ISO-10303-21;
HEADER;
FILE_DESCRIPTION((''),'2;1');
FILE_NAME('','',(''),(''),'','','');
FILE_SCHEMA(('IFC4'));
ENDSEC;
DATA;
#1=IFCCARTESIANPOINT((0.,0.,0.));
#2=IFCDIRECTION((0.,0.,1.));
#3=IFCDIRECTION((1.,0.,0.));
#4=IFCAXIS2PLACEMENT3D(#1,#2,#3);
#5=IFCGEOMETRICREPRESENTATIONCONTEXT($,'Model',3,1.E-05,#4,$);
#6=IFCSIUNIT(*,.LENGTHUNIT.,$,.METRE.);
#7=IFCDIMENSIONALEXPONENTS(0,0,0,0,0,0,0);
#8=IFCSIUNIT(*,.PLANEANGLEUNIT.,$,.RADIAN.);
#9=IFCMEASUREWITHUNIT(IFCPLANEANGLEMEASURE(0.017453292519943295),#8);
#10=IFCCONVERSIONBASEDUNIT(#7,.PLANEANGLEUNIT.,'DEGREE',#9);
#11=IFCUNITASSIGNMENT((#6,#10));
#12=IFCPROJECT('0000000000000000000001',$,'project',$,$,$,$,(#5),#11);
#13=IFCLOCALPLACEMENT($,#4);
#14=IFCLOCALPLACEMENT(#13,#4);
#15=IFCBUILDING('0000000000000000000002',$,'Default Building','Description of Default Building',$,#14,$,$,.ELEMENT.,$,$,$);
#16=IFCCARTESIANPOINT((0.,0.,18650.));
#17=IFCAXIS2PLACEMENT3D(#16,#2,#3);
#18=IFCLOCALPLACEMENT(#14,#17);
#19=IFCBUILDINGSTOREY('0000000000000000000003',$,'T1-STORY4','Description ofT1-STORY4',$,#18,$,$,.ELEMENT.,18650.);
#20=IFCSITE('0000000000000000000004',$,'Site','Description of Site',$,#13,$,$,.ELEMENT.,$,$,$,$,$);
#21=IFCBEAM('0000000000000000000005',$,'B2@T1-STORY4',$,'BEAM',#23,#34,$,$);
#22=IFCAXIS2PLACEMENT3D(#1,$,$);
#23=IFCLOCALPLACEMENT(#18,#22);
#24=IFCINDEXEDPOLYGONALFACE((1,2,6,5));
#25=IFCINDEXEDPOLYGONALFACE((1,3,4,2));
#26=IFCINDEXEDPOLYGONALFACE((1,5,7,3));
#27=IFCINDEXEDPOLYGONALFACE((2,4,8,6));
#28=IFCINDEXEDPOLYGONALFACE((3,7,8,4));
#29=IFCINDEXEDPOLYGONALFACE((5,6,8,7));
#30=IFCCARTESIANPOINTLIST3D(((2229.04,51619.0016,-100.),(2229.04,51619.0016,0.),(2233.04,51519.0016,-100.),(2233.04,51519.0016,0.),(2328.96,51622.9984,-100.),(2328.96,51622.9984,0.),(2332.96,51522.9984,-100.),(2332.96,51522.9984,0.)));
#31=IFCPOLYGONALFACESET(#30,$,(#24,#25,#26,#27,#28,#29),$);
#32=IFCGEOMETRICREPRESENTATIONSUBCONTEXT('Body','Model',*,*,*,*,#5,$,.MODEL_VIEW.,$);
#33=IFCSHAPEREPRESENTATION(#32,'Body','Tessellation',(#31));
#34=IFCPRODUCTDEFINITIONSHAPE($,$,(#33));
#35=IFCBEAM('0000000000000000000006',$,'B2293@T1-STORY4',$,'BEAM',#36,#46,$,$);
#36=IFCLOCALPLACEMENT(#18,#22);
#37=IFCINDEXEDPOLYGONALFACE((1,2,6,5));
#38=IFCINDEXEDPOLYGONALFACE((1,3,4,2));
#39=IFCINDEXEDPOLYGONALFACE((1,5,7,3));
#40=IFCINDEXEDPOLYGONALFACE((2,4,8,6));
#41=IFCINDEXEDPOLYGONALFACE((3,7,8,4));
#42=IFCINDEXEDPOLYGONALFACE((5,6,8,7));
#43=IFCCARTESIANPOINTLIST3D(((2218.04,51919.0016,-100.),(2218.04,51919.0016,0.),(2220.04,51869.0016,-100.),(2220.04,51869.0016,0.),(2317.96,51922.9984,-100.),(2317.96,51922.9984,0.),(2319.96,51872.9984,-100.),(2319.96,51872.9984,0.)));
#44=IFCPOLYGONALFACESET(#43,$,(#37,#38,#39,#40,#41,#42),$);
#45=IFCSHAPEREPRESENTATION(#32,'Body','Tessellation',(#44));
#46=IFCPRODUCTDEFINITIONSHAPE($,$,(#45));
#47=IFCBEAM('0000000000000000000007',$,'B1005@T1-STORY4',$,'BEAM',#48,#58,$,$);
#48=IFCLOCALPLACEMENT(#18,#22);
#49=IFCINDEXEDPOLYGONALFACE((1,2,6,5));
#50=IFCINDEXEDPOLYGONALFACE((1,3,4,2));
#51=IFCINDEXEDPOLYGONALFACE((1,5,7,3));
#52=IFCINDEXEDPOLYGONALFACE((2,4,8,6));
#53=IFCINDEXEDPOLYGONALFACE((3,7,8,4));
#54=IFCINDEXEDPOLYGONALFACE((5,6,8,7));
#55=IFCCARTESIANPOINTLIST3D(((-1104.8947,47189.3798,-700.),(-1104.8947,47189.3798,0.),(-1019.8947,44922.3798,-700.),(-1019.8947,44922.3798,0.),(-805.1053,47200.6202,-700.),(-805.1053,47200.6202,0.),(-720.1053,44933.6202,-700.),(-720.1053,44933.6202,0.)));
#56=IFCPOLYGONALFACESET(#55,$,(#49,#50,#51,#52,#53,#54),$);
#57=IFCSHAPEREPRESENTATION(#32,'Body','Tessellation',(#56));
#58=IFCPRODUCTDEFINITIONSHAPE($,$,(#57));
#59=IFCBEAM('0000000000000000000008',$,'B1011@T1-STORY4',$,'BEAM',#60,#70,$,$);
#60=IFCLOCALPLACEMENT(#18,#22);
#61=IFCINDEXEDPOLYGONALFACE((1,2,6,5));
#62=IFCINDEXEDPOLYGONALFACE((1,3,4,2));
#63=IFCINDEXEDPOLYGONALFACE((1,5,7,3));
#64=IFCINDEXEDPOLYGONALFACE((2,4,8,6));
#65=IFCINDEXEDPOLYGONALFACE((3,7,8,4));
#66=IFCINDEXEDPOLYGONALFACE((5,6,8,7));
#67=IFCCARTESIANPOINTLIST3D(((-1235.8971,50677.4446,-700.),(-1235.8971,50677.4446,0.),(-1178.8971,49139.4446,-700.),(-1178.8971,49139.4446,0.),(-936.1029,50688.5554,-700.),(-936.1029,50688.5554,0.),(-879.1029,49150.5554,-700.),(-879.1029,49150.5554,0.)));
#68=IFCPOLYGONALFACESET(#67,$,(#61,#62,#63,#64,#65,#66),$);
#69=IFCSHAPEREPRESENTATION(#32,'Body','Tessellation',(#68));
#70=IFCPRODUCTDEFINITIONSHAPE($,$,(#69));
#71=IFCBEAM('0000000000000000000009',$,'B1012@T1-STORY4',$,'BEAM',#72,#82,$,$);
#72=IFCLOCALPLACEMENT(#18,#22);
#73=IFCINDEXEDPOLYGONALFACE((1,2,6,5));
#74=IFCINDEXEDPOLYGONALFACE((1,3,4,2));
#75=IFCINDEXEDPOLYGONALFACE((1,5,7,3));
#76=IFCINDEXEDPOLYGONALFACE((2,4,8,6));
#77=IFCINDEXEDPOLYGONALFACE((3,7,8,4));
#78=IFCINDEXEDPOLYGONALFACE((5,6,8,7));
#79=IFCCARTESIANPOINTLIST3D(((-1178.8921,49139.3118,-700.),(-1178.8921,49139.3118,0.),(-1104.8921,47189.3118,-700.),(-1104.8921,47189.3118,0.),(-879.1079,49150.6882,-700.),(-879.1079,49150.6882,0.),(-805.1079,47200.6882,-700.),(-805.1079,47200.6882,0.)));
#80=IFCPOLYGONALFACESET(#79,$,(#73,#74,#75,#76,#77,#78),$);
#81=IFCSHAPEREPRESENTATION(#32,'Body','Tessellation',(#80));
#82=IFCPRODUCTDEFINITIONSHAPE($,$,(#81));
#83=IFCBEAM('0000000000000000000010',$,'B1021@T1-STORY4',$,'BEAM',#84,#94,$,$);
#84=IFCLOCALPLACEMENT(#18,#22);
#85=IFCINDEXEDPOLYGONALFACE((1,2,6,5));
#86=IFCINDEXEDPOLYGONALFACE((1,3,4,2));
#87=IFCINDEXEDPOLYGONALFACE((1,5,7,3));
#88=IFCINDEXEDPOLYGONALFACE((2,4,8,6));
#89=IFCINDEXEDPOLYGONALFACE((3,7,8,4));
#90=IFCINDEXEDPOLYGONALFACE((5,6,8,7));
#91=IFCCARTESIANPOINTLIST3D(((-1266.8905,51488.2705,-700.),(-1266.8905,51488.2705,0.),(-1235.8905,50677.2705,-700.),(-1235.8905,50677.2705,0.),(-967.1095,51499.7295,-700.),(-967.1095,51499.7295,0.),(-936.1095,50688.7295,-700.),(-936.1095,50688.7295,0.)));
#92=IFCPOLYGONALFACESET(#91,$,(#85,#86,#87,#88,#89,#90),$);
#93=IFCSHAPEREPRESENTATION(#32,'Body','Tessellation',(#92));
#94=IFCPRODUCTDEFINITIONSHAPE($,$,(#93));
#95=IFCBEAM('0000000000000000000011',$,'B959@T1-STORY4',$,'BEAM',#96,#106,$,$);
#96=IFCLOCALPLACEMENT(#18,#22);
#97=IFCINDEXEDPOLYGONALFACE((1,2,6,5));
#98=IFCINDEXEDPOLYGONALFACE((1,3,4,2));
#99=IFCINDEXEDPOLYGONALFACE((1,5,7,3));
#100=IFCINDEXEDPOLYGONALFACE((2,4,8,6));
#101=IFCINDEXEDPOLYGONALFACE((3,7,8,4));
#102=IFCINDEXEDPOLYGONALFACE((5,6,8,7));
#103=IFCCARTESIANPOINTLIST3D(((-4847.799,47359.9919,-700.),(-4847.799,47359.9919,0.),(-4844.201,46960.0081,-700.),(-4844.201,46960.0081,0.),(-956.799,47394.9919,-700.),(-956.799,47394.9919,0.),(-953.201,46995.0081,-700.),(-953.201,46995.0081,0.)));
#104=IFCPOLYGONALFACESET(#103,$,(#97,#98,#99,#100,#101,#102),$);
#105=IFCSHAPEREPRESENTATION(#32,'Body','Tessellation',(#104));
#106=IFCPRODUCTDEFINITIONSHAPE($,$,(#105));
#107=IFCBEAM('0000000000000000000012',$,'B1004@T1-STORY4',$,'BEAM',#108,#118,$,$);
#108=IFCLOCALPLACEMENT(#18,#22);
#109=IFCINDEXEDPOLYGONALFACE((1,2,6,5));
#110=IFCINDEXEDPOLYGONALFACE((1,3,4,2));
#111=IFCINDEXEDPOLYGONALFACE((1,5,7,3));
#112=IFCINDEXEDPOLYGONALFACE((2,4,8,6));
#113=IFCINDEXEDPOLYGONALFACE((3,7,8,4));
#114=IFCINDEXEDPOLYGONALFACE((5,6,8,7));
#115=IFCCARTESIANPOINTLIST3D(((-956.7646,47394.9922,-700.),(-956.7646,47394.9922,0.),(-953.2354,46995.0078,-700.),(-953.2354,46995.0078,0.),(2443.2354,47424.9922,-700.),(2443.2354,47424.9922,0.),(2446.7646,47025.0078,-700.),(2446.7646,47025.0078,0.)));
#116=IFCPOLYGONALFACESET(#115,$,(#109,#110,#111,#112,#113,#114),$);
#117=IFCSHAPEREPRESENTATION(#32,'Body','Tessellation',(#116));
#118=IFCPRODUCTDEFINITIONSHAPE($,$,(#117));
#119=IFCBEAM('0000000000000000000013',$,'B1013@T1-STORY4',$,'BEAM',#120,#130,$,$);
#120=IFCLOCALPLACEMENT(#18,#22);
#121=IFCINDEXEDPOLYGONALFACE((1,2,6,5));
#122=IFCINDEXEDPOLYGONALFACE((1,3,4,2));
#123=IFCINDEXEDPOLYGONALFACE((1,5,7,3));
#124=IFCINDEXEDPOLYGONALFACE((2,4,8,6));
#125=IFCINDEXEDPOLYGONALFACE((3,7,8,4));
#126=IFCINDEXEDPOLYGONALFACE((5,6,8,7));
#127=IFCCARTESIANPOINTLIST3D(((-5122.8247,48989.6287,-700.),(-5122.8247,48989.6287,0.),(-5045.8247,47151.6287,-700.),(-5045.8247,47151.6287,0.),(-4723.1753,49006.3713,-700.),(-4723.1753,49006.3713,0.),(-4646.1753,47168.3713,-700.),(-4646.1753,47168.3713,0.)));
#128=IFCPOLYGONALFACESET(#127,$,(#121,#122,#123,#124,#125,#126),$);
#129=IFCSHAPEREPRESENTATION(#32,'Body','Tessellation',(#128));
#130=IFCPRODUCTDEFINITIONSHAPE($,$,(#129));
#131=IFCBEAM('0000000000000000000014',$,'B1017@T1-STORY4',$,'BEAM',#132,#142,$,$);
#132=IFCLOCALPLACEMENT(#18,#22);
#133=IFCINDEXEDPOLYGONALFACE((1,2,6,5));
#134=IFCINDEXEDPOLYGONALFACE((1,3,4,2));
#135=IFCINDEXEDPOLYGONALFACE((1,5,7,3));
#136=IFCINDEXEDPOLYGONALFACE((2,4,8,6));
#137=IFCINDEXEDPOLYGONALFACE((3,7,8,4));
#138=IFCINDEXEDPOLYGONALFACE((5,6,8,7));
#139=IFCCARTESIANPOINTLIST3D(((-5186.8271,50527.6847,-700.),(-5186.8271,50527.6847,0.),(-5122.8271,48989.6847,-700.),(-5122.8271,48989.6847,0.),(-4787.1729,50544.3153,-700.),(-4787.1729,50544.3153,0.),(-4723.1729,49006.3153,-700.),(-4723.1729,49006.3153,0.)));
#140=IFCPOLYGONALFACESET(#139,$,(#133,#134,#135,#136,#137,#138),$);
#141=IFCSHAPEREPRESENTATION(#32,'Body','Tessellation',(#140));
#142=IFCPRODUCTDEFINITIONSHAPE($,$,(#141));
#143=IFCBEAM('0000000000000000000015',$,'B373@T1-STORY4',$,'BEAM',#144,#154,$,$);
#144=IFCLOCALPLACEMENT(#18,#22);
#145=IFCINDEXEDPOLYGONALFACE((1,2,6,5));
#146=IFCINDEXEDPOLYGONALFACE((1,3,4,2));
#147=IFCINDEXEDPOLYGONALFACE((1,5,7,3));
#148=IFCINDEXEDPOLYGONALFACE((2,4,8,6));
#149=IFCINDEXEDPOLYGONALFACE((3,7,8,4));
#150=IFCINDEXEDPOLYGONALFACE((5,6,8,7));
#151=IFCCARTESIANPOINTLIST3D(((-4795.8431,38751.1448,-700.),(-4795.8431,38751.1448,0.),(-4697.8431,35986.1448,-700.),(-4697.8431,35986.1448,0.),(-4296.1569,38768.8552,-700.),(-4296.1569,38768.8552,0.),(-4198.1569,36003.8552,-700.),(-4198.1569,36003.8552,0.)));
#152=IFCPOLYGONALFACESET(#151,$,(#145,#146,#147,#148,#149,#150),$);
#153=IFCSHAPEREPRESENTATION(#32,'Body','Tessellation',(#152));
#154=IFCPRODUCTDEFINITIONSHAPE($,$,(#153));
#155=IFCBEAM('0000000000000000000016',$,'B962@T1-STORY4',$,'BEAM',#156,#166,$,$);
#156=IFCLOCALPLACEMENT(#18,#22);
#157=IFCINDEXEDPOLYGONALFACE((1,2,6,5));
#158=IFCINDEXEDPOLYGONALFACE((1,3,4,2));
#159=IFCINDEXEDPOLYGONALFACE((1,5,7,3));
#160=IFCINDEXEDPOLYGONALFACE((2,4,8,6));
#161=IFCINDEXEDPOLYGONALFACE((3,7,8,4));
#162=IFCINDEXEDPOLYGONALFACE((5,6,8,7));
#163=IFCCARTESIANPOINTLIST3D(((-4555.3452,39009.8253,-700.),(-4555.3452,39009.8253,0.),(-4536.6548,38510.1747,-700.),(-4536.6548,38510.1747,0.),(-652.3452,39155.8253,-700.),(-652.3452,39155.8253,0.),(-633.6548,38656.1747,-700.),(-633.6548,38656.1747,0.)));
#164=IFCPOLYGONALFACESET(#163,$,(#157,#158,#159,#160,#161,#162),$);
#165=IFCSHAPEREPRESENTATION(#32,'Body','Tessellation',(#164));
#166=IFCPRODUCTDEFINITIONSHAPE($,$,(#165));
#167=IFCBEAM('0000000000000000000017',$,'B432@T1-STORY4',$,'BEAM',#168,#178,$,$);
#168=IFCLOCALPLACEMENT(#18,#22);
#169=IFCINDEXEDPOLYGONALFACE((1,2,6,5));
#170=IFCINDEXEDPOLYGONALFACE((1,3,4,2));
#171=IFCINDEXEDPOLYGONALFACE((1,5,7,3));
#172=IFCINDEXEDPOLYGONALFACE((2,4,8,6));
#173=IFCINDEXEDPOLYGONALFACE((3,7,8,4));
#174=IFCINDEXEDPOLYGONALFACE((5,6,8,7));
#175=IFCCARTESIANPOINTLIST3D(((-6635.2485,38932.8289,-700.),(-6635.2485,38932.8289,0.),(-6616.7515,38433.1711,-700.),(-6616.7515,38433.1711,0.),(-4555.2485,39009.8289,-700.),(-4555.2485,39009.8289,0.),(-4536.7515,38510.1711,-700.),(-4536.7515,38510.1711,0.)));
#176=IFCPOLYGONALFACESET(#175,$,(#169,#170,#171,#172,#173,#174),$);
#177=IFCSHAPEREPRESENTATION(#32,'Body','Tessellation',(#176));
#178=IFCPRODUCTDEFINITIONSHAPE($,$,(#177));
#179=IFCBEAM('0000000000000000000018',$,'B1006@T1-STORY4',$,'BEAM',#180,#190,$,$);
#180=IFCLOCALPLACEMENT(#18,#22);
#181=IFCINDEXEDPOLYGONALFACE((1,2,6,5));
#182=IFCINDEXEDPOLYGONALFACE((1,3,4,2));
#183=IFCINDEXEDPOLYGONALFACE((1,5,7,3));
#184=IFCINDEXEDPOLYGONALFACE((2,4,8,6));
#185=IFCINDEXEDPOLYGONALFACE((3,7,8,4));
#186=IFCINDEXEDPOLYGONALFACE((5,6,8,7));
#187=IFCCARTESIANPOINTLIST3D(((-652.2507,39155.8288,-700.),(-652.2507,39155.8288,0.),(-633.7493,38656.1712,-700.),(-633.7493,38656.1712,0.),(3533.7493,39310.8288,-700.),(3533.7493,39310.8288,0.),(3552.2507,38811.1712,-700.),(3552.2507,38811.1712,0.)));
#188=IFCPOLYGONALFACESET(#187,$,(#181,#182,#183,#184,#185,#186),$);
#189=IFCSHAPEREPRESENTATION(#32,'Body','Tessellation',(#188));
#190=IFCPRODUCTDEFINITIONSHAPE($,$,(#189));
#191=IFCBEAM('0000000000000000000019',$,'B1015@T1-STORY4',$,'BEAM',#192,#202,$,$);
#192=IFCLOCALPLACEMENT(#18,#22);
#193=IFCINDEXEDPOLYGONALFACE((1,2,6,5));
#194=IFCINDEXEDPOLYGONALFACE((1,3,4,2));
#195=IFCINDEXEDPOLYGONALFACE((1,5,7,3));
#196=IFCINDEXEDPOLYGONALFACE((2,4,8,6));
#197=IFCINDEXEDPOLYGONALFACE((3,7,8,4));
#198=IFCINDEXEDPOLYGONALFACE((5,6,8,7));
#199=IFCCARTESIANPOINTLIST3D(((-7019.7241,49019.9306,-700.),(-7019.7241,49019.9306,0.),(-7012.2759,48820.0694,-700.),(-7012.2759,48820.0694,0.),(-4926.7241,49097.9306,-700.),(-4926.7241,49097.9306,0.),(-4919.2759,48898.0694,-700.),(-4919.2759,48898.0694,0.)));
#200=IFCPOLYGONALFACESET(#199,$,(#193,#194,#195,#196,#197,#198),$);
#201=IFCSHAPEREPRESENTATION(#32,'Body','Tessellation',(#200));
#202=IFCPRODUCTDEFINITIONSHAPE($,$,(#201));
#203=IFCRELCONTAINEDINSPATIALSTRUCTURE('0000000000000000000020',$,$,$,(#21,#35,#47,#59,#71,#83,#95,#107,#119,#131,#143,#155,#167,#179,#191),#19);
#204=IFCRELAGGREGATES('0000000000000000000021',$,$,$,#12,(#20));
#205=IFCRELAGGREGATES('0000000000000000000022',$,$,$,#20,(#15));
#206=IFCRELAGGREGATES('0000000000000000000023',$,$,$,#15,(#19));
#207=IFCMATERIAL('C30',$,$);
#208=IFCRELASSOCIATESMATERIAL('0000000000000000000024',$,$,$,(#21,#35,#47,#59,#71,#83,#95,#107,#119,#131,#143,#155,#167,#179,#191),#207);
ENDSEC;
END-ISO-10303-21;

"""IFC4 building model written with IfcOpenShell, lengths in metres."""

from ifc_helpers import new_model, entity, si_unit, converted_unit, frame, origin_with_axes, place, context, subcontext, project, spatial, rectangle, extrude, material, element, save


model = new_model("IFC4")

# Units and contexts
model_context = context("Model", 3, precision=1e-05, world=origin_with_axes())
body_context = subcontext(model_context, "Body", "Model", "MODEL_VIEW")
ifc_project = project(units=[si_unit("LENGTHUNIT", "METRE"), converted_unit("PLANEANGLEUNIT", "DEGREE", entity("IfcPlaneAngleMeasure", 0.017453292519943295), si_unit("PLANEANGLEUNIT", "RADIAN"), dimensions=[0, 0, 0, 0, 0, 0, 0])], contexts=[model_context])

# Site, building, storey
site_placement = place(None, origin_with_axes())
site = spatial("IfcSite", under=ifc_project, at=site_placement, Name="Site", Description="Description of Site", CompositionType="ELEMENT")
building_placement = place(site_placement, origin_with_axes())
building = spatial("IfcBuilding", under=site, at=building_placement, Name="Default Building", Description="Description of Default Building", CompositionType="ELEMENT")
storey_placement = place(building_placement, frame((0.0, 0.0, 18650.0), z_axis=(0.0, 0.0, 1.0), x_axis=(1.0, 0.0, 0.0)))
storey = spatial("IfcBuildingStorey", under=building, at=storey_placement, Name="T1-STORY4", Description="Description ofT1-STORY4", CompositionType="ELEMENT", Elevation=18650.0)

# Beams
ifc_material_1 = material(Name="C30")
beam_1_placement = place(storey_placement, frame((2279.0, 51621.0, -50.0), z_axis=(0.039968, -0.999201, 0.0), x_axis=(0.999201, 0.039968, 0.0)))
element("IfcBeam", 1, at=beam_1_placement, inside=storey, material=ifc_material_1, Name="B2@T1-STORY4", ObjectType="BEAM", context=body_context, shape_type="SweptSolid", body=[
    extrude(rectangle(XDim=100.0, YDim=100.0), origin_with_axes(), (0.0, 0.0, 1.0), 100.08),
])
beam_2_placement = place(storey_placement, frame((2268.0, 51921.0, -50.0), z_axis=(0.039968, -0.999201, 0.0), x_axis=(0.999201, 0.039968, 0.0)))
element("IfcBeam", 2, at=beam_2_placement, inside=storey, material=ifc_material_1, Name="B2293@T1-STORY4", ObjectType="BEAM", context=body_context, shape_type="SweptSolid", body=[
    extrude(rectangle(XDim=100.0, YDim=100.0), origin_with_axes(), (0.0, 0.0, 1.0), 50.04),
])
beam_3_placement = place(storey_placement, frame((-955.0, 47195.0, -350.0), z_axis=(0.037468, -0.999298, 0.0), x_axis=(0.999298, 0.037468, 0.0)))
element("IfcBeam", 3, at=beam_3_placement, inside=storey, material=ifc_material_1, Name="B1005@T1-STORY4", ObjectType="BEAM", context=body_context, shape_type="SweptSolid", body=[
    extrude(rectangle(XDim=300.0, YDim=700.0), origin_with_axes(), (0.0, 0.0, 1.0), 2268.593),
])
beam_4_placement = place(storey_placement, frame((-1086.0, 50683.0, -350.0), z_axis=(0.037036, -0.999314, 0.0), x_axis=(0.999314, 0.037036, 0.0)))
element("IfcBeam", 4, at=beam_4_placement, inside=storey, material=ifc_material_1, Name="B1011@T1-STORY4", ObjectType="BEAM", context=body_context, shape_type="SweptSolid", body=[
    extrude(rectangle(XDim=300.0, YDim=700.0), origin_with_axes(), (0.0, 0.0, 1.0), 1539.0559),
])
beam_5_placement = place(storey_placement, frame((-1029.0, 49145.0, -350.0), z_axis=(0.037921, -0.999281, 0.0), x_axis=(0.999281, 0.037921, 0.0)))
element("IfcBeam", 5, at=beam_5_placement, inside=storey, material=ifc_material_1, Name="B1012@T1-STORY4", ObjectType="BEAM", context=body_context, shape_type="SweptSolid", body=[
    extrude(rectangle(XDim=300.0, YDim=700.0), origin_with_axes(), (0.0, 0.0, 1.0), 1951.4036),
])
beam_6_placement = place(storey_placement, frame((-1117.0, 51494.0, -350.0), z_axis=(0.038197, -0.99927, 0.0), x_axis=(0.99927, 0.038197, 0.0)))
element("IfcBeam", 6, at=beam_6_placement, inside=storey, material=ifc_material_1, Name="B1021@T1-STORY4", ObjectType="BEAM", context=body_context, shape_type="SweptSolid", body=[
    extrude(rectangle(XDim=300.0, YDim=700.0), origin_with_axes(), (0.0, 0.0, 1.0), 811.5923),
])
beam_7_placement = place(storey_placement, frame((-4846.0, 47160.0, -350.0), z_axis=(0.99996, 0.008995, 0.0), x_axis=(-0.008995, 0.99996, 0.0)))
element("IfcBeam", 7, at=beam_7_placement, inside=storey, material=ifc_material_1, Name="B959@T1-STORY4", ObjectType="BEAM", context=body_context, shape_type="SweptSolid", body=[
    extrude(rectangle(XDim=400.0, YDim=700.0), origin_with_axes(), (0.0, 0.0, 1.0), 3891.1574),
])
beam_8_placement = place(storey_placement, frame((-955.0, 47195.0, -350.0), z_axis=(0.999961, 0.008823, 0.0), x_axis=(-0.008823, 0.999961, 0.0)))
element("IfcBeam", 8, at=beam_8_placement, inside=storey, material=ifc_material_1, Name="B1004@T1-STORY4", ObjectType="BEAM", context=body_context, shape_type="SweptSolid", body=[
    extrude(rectangle(XDim=400.0, YDim=700.0), origin_with_axes(), (0.0, 0.0, 1.0), 3400.1324),
])
beam_9_placement = place(storey_placement, frame((-4923.0, 48998.0, -350.0), z_axis=(0.041857, -0.999124, 0.0), x_axis=(0.999124, 0.041857, 0.0)))
element("IfcBeam", 9, at=beam_9_placement, inside=storey, material=ifc_material_1, Name="B1013@T1-STORY4", ObjectType="BEAM", context=body_context, shape_type="SweptSolid", body=[
    extrude(rectangle(XDim=400.0, YDim=700.0), origin_with_axes(), (0.0, 0.0, 1.0), 1839.6122),
])
beam_10_placement = place(storey_placement, frame((-4987.0, 50536.0, -350.0), z_axis=(0.041577, -0.999135, 0.0), x_axis=(0.999135, 0.041577, 0.0)))
element("IfcBeam", 10, at=beam_10_placement, inside=storey, material=ifc_material_1, Name="B1017@T1-STORY4", ObjectType="BEAM", context=body_context, shape_type="SweptSolid", body=[
    extrude(rectangle(XDim=400.0, YDim=700.0), origin_with_axes(), (0.0, 0.0, 1.0), 1539.331),
])
beam_11_placement = place(storey_placement, frame((-4546.0, 38760.0, -350.0), z_axis=(0.035421, -0.999372, 0.0), x_axis=(0.999372, 0.035421, 0.0)))
element("IfcBeam", 11, at=beam_11_placement, inside=storey, material=ifc_material_1, Name="B373@T1-STORY4", ObjectType="BEAM", context=body_context, shape_type="SweptSolid", body=[
    extrude(rectangle(XDim=500.0, YDim=700.0), origin_with_axes(), (0.0, 0.0, 1.0), 2766.7362),
])
beam_12_placement = place(storey_placement, frame((-4546.0, 38760.0, -350.0), z_axis=(0.999301, 0.037381, 0.0), x_axis=(-0.037381, 0.999301, 0.0)))
element("IfcBeam", 12, at=beam_12_placement, inside=storey, material=ifc_material_1, Name="B962@T1-STORY4", ObjectType="BEAM", context=body_context, shape_type="SweptSolid", body=[
    extrude(rectangle(XDim=500.0, YDim=700.0), origin_with_axes(), (0.0, 0.0, 1.0), 3905.7298),
])
beam_13_placement = place(storey_placement, frame((-6626.0, 38683.0, -350.0), z_axis=(0.999315, 0.036994, 0.0), x_axis=(-0.036994, 0.999315, 0.0)))
element("IfcBeam", 13, at=beam_13_placement, inside=storey, material=ifc_material_1, Name="B432@T1-STORY4", ObjectType="BEAM", context=body_context, shape_type="SweptSolid", body=[
    extrude(rectangle(XDim=500.0, YDim=700.0), origin_with_axes(), (0.0, 0.0, 1.0), 2081.4248),
])
beam_14_placement = place(storey_placement, frame((-643.0, 38906.0, -350.0), z_axis=(0.999315, 0.037003, 0.0), x_axis=(-0.037003, 0.999315, 0.0)))
element("IfcBeam", 14, at=beam_14_placement, inside=storey, material=ifc_material_1, Name="B1006@T1-STORY4", ObjectType="BEAM", context=body_context, shape_type="SweptSolid", body=[
    extrude(rectangle(XDim=500.0, YDim=700.0), origin_with_axes(), (0.0, 0.0, 1.0), 4188.8687),
])
beam_15_placement = place(storey_placement, frame((-7016.0, 48920.0, -350.0), z_axis=(0.999306, 0.037241, 0.0), x_axis=(-0.037241, 0.999306, 0.0)))
element("IfcBeam", 15, at=beam_15_placement, inside=storey, material=ifc_material_1, Name="B1015@T1-STORY4", ObjectType="BEAM", context=body_context, shape_type="SweptSolid", body=[
    extrude(rectangle(XDim=200.0, YDim=700.0), origin_with_axes(), (0.0, 0.0, 1.0), 2094.4529),
])

save(model, "model.ifc")
